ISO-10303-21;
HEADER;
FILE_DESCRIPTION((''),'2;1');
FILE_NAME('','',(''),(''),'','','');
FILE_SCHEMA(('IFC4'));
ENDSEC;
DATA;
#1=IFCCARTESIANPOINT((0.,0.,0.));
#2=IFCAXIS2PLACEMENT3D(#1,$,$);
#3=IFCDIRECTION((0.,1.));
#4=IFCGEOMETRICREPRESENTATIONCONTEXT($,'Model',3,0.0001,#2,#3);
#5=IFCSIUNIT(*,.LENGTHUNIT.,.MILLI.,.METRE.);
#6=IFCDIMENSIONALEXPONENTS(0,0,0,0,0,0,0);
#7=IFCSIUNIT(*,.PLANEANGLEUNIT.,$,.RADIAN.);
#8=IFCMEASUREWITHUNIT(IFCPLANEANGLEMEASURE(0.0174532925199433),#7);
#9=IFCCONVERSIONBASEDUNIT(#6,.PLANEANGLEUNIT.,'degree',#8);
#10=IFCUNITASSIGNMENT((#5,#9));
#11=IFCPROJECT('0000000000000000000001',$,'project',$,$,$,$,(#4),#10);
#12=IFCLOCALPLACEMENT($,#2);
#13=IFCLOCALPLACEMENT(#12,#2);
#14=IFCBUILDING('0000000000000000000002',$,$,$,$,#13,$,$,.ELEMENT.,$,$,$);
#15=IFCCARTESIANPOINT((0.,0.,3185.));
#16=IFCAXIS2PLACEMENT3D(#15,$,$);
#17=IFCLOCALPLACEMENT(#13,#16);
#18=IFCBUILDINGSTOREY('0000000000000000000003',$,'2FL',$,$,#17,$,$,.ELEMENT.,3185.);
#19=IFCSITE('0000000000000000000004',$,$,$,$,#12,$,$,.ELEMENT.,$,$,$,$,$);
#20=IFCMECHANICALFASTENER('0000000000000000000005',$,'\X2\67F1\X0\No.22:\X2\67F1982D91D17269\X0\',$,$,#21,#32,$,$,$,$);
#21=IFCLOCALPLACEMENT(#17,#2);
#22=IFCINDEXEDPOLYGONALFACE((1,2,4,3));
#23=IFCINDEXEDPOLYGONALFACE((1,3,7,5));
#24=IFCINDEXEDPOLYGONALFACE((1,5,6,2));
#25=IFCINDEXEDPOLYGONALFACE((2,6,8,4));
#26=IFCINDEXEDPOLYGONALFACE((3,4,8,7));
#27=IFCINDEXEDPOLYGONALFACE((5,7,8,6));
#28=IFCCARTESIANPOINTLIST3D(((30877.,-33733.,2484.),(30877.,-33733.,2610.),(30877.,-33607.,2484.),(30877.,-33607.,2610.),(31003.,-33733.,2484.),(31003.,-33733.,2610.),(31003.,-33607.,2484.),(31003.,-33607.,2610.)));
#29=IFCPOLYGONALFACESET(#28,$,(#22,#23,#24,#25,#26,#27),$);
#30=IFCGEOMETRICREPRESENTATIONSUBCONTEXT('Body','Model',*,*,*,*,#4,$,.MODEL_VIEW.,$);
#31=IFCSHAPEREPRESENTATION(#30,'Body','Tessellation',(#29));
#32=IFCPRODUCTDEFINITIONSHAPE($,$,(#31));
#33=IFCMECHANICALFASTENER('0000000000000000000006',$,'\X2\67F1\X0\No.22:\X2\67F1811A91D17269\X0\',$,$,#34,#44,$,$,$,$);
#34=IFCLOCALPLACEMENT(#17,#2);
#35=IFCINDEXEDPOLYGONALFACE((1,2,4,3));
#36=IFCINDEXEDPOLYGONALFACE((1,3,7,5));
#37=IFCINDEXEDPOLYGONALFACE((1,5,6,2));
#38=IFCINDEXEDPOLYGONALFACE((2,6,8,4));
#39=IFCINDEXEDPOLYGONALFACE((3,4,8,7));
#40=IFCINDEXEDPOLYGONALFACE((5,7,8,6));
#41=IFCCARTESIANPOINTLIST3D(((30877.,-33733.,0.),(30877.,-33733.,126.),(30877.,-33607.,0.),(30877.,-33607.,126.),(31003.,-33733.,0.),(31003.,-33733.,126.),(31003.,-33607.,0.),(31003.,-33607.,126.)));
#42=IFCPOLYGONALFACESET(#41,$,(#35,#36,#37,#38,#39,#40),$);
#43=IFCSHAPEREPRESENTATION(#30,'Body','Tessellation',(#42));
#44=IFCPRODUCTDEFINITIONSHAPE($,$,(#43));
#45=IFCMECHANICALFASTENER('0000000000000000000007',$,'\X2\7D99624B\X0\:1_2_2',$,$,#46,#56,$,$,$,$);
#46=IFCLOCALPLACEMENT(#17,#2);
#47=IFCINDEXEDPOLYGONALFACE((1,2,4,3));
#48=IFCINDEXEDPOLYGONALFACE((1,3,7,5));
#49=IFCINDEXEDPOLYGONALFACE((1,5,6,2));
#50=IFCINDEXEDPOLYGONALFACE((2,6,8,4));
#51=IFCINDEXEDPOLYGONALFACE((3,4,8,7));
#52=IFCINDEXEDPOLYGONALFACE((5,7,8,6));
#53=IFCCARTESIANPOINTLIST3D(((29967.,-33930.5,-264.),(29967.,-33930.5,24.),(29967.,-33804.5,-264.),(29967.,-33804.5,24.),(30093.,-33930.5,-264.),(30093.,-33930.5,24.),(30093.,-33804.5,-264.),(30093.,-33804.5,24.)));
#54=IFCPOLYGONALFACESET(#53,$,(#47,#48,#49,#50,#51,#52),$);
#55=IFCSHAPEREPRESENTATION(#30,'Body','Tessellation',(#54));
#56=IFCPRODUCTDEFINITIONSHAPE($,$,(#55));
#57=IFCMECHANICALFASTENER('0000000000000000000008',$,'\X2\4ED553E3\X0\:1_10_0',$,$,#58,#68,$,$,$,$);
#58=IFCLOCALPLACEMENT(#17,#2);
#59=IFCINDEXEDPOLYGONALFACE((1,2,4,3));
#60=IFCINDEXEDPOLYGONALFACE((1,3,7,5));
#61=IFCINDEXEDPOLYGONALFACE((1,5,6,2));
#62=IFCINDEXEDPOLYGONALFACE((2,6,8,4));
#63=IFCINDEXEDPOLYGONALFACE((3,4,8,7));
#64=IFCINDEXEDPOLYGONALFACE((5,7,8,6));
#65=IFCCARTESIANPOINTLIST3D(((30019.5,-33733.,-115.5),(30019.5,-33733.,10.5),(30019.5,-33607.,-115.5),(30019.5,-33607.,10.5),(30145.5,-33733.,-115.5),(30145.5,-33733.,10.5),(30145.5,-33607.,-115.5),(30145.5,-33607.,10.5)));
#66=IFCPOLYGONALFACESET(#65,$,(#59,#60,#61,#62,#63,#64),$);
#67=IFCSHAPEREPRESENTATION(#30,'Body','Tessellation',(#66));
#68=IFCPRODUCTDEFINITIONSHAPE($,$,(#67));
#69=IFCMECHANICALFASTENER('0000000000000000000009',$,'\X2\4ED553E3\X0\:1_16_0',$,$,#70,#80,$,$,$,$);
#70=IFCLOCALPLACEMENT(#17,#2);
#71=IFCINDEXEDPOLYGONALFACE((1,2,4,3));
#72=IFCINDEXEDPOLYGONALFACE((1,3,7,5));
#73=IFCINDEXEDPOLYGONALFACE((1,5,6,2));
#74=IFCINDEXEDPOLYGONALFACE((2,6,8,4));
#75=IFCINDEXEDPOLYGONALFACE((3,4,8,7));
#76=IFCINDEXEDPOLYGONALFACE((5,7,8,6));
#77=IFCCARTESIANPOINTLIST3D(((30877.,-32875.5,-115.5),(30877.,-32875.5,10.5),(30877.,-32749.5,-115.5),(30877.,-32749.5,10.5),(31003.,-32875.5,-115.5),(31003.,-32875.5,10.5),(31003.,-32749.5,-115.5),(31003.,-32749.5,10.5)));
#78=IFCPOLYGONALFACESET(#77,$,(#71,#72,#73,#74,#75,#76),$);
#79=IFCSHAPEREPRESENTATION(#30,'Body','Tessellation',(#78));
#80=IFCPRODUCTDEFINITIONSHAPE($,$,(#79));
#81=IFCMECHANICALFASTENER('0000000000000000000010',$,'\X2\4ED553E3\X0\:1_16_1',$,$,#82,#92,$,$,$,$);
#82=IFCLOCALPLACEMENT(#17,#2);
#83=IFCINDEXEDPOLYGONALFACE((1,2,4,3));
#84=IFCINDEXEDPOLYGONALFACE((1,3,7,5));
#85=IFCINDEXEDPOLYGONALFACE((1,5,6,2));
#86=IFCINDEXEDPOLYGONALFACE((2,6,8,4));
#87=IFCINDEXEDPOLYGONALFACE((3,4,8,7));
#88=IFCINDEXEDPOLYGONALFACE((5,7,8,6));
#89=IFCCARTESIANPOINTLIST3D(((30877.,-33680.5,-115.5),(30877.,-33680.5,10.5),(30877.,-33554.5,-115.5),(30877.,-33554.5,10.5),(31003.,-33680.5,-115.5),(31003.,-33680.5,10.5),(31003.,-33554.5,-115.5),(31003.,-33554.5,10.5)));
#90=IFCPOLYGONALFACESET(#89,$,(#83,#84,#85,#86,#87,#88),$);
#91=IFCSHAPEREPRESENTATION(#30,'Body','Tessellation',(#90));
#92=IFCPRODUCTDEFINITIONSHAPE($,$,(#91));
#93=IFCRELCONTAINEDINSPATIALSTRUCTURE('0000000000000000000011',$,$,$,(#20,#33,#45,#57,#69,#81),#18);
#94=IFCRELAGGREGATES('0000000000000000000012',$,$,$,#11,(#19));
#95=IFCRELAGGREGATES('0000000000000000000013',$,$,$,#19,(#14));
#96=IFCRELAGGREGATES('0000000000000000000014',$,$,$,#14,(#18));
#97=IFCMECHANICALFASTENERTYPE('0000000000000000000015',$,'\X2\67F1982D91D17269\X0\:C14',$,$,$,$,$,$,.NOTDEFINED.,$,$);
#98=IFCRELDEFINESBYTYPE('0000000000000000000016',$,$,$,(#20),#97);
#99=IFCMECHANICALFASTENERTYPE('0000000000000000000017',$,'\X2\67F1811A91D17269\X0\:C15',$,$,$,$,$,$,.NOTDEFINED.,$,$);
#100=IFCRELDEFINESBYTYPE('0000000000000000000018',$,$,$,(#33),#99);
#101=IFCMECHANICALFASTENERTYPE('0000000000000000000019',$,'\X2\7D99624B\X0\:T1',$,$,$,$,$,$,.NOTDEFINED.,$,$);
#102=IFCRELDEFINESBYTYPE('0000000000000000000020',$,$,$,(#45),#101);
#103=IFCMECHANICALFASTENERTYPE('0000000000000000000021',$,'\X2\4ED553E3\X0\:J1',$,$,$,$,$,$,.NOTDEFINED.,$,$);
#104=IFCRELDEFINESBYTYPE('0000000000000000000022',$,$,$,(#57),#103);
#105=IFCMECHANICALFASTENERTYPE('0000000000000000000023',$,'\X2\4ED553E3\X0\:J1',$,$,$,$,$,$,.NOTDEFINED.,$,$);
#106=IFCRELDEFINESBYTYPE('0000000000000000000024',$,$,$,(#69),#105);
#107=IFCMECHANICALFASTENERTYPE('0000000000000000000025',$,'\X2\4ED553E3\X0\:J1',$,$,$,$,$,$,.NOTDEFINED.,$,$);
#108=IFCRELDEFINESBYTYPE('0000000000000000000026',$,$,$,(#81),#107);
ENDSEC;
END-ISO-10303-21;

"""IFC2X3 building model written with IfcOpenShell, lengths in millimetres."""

from ifc_helpers import new_model, entity, si_unit, converted_unit, direction, frame, origin, origin_with_axes, origin_2d, place, context, subcontext, project, spatial, rectangle, extrude, type_object, element, save


model = new_model("IFC2X3")

# Units and contexts
model_context = context("Model", 3, precision=0.0001, world=origin(), true_north=direction((0.0, 1.0)))
body_context = subcontext(model_context, "Body", "Model", "MODEL_VIEW")
ifc_project = project(units=[si_unit("LENGTHUNIT", "METRE", prefix="MILLI"), converted_unit("PLANEANGLEUNIT", "degree", entity("IfcPlaneAngleMeasure", 0.0174532925199433), si_unit("PLANEANGLEUNIT", "RADIAN"), dimensions=[0, 0, 0, 0, 0, 0, 0])], contexts=[model_context])

# Site, building, storey
site_placement = place(None, origin())
site = spatial("IfcSite", under=ifc_project, at=site_placement, CompositionType="ELEMENT")
building_placement = place(site_placement, origin())
building = spatial("IfcBuilding", under=site, at=building_placement, CompositionType="ELEMENT")
storey_placement = place(building_placement, frame((0.0, 0.0, 3185.0)))
storey = spatial("IfcBuildingStorey", under=building, at=storey_placement, Name="2FL", CompositionType="ELEMENT", Elevation=3185.0)

# Mechanical fasteners
mechanical_fastener_type_1 = type_object("IfcMechanicalFastenerType", Name="柱頭金物:C14")
mechanical_fastener_1_placement = place(storey_placement, frame((30940.0, -33670.0, 2484.0)))
element("IfcMechanicalFastener", 1, at=mechanical_fastener_1_placement, inside=storey, type_object=mechanical_fastener_type_1, Name="柱No.22:柱頭金物", context=body_context, shape_type="SweptSolid", body=[
    extrude(rectangle(XDim=126.0, YDim=126.0, at=origin_2d()), origin_with_axes(), (0.0, 0.0, 1.0), 126.0),
])
mechanical_fastener_type_2 = type_object("IfcMechanicalFastenerType", Name="柱脚金物:C15")
mechanical_fastener_2_placement = place(storey_placement, frame((30940.0, -33670.0, 0.0)))
element("IfcMechanicalFastener", 2, at=mechanical_fastener_2_placement, inside=storey, type_object=mechanical_fastener_type_2, Name="柱No.22:柱脚金物", context=body_context, shape_type="SweptSolid", body=[
    extrude(rectangle(XDim=126.0, YDim=126.0, at=origin_2d()), origin_with_axes(), (0.0, 0.0, 1.0), 126.0),
])
mechanical_fastener_type_3 = type_object("IfcMechanicalFastenerType", Name="継手:T1")
mechanical_fastener_3_placement = place(storey_placement, frame((30030.0, -33867.5, -264.0)))
element("IfcMechanicalFastener", 3, at=mechanical_fastener_3_placement, inside=storey, type_object=mechanical_fastener_type_3, Name="継手:1_2_2", context=body_context, shape_type="SweptSolid", body=[
    extrude(rectangle(XDim=126.0, YDim=126.0, at=origin_2d()), origin_with_axes(), (0.0, 0.0, 1.0), 288.0),
])
mechanical_fastener_type_4 = type_object("IfcMechanicalFastenerType", Name="仕口:J1")
mechanical_fastener_4_placement = place(storey_placement, frame((30082.5, -33670.0, -115.5)))
element("IfcMechanicalFastener", 4, at=mechanical_fastener_4_placement, inside=storey, type_object=mechanical_fastener_type_4, Name="仕口:1_10_0", context=body_context, shape_type="SweptSolid", body=[
    extrude(rectangle(XDim=126.0, YDim=126.0, at=origin_2d()), origin_with_axes(), (0.0, 0.0, 1.0), 126.0),
])
mechanical_fastener_type_5 = type_object("IfcMechanicalFastenerType", Name="仕口:J1")
mechanical_fastener_5_placement = place(storey_placement, frame((30940.0, -32812.5, -115.5)))
element("IfcMechanicalFastener", 5, at=mechanical_fastener_5_placement, inside=storey, type_object=mechanical_fastener_type_5, Name="仕口:1_16_0", context=body_context, shape_type="SweptSolid", body=[
    extrude(rectangle(XDim=126.0, YDim=126.0, at=origin_2d()), origin_with_axes(), (0.0, 0.0, 1.0), 126.0),
])
mechanical_fastener_type_6 = type_object("IfcMechanicalFastenerType", Name="仕口:J1")
mechanical_fastener_6_placement = place(storey_placement, frame((30940.0, -33617.5, -115.5)))
element("IfcMechanicalFastener", 6, at=mechanical_fastener_6_placement, inside=storey, type_object=mechanical_fastener_type_6, Name="仕口:1_16_1", context=body_context, shape_type="SweptSolid", body=[
    extrude(rectangle(XDim=126.0, YDim=126.0, at=origin_2d()), origin_with_axes(), (0.0, 0.0, 1.0), 126.0),
])

save(model, "model.ifc")
